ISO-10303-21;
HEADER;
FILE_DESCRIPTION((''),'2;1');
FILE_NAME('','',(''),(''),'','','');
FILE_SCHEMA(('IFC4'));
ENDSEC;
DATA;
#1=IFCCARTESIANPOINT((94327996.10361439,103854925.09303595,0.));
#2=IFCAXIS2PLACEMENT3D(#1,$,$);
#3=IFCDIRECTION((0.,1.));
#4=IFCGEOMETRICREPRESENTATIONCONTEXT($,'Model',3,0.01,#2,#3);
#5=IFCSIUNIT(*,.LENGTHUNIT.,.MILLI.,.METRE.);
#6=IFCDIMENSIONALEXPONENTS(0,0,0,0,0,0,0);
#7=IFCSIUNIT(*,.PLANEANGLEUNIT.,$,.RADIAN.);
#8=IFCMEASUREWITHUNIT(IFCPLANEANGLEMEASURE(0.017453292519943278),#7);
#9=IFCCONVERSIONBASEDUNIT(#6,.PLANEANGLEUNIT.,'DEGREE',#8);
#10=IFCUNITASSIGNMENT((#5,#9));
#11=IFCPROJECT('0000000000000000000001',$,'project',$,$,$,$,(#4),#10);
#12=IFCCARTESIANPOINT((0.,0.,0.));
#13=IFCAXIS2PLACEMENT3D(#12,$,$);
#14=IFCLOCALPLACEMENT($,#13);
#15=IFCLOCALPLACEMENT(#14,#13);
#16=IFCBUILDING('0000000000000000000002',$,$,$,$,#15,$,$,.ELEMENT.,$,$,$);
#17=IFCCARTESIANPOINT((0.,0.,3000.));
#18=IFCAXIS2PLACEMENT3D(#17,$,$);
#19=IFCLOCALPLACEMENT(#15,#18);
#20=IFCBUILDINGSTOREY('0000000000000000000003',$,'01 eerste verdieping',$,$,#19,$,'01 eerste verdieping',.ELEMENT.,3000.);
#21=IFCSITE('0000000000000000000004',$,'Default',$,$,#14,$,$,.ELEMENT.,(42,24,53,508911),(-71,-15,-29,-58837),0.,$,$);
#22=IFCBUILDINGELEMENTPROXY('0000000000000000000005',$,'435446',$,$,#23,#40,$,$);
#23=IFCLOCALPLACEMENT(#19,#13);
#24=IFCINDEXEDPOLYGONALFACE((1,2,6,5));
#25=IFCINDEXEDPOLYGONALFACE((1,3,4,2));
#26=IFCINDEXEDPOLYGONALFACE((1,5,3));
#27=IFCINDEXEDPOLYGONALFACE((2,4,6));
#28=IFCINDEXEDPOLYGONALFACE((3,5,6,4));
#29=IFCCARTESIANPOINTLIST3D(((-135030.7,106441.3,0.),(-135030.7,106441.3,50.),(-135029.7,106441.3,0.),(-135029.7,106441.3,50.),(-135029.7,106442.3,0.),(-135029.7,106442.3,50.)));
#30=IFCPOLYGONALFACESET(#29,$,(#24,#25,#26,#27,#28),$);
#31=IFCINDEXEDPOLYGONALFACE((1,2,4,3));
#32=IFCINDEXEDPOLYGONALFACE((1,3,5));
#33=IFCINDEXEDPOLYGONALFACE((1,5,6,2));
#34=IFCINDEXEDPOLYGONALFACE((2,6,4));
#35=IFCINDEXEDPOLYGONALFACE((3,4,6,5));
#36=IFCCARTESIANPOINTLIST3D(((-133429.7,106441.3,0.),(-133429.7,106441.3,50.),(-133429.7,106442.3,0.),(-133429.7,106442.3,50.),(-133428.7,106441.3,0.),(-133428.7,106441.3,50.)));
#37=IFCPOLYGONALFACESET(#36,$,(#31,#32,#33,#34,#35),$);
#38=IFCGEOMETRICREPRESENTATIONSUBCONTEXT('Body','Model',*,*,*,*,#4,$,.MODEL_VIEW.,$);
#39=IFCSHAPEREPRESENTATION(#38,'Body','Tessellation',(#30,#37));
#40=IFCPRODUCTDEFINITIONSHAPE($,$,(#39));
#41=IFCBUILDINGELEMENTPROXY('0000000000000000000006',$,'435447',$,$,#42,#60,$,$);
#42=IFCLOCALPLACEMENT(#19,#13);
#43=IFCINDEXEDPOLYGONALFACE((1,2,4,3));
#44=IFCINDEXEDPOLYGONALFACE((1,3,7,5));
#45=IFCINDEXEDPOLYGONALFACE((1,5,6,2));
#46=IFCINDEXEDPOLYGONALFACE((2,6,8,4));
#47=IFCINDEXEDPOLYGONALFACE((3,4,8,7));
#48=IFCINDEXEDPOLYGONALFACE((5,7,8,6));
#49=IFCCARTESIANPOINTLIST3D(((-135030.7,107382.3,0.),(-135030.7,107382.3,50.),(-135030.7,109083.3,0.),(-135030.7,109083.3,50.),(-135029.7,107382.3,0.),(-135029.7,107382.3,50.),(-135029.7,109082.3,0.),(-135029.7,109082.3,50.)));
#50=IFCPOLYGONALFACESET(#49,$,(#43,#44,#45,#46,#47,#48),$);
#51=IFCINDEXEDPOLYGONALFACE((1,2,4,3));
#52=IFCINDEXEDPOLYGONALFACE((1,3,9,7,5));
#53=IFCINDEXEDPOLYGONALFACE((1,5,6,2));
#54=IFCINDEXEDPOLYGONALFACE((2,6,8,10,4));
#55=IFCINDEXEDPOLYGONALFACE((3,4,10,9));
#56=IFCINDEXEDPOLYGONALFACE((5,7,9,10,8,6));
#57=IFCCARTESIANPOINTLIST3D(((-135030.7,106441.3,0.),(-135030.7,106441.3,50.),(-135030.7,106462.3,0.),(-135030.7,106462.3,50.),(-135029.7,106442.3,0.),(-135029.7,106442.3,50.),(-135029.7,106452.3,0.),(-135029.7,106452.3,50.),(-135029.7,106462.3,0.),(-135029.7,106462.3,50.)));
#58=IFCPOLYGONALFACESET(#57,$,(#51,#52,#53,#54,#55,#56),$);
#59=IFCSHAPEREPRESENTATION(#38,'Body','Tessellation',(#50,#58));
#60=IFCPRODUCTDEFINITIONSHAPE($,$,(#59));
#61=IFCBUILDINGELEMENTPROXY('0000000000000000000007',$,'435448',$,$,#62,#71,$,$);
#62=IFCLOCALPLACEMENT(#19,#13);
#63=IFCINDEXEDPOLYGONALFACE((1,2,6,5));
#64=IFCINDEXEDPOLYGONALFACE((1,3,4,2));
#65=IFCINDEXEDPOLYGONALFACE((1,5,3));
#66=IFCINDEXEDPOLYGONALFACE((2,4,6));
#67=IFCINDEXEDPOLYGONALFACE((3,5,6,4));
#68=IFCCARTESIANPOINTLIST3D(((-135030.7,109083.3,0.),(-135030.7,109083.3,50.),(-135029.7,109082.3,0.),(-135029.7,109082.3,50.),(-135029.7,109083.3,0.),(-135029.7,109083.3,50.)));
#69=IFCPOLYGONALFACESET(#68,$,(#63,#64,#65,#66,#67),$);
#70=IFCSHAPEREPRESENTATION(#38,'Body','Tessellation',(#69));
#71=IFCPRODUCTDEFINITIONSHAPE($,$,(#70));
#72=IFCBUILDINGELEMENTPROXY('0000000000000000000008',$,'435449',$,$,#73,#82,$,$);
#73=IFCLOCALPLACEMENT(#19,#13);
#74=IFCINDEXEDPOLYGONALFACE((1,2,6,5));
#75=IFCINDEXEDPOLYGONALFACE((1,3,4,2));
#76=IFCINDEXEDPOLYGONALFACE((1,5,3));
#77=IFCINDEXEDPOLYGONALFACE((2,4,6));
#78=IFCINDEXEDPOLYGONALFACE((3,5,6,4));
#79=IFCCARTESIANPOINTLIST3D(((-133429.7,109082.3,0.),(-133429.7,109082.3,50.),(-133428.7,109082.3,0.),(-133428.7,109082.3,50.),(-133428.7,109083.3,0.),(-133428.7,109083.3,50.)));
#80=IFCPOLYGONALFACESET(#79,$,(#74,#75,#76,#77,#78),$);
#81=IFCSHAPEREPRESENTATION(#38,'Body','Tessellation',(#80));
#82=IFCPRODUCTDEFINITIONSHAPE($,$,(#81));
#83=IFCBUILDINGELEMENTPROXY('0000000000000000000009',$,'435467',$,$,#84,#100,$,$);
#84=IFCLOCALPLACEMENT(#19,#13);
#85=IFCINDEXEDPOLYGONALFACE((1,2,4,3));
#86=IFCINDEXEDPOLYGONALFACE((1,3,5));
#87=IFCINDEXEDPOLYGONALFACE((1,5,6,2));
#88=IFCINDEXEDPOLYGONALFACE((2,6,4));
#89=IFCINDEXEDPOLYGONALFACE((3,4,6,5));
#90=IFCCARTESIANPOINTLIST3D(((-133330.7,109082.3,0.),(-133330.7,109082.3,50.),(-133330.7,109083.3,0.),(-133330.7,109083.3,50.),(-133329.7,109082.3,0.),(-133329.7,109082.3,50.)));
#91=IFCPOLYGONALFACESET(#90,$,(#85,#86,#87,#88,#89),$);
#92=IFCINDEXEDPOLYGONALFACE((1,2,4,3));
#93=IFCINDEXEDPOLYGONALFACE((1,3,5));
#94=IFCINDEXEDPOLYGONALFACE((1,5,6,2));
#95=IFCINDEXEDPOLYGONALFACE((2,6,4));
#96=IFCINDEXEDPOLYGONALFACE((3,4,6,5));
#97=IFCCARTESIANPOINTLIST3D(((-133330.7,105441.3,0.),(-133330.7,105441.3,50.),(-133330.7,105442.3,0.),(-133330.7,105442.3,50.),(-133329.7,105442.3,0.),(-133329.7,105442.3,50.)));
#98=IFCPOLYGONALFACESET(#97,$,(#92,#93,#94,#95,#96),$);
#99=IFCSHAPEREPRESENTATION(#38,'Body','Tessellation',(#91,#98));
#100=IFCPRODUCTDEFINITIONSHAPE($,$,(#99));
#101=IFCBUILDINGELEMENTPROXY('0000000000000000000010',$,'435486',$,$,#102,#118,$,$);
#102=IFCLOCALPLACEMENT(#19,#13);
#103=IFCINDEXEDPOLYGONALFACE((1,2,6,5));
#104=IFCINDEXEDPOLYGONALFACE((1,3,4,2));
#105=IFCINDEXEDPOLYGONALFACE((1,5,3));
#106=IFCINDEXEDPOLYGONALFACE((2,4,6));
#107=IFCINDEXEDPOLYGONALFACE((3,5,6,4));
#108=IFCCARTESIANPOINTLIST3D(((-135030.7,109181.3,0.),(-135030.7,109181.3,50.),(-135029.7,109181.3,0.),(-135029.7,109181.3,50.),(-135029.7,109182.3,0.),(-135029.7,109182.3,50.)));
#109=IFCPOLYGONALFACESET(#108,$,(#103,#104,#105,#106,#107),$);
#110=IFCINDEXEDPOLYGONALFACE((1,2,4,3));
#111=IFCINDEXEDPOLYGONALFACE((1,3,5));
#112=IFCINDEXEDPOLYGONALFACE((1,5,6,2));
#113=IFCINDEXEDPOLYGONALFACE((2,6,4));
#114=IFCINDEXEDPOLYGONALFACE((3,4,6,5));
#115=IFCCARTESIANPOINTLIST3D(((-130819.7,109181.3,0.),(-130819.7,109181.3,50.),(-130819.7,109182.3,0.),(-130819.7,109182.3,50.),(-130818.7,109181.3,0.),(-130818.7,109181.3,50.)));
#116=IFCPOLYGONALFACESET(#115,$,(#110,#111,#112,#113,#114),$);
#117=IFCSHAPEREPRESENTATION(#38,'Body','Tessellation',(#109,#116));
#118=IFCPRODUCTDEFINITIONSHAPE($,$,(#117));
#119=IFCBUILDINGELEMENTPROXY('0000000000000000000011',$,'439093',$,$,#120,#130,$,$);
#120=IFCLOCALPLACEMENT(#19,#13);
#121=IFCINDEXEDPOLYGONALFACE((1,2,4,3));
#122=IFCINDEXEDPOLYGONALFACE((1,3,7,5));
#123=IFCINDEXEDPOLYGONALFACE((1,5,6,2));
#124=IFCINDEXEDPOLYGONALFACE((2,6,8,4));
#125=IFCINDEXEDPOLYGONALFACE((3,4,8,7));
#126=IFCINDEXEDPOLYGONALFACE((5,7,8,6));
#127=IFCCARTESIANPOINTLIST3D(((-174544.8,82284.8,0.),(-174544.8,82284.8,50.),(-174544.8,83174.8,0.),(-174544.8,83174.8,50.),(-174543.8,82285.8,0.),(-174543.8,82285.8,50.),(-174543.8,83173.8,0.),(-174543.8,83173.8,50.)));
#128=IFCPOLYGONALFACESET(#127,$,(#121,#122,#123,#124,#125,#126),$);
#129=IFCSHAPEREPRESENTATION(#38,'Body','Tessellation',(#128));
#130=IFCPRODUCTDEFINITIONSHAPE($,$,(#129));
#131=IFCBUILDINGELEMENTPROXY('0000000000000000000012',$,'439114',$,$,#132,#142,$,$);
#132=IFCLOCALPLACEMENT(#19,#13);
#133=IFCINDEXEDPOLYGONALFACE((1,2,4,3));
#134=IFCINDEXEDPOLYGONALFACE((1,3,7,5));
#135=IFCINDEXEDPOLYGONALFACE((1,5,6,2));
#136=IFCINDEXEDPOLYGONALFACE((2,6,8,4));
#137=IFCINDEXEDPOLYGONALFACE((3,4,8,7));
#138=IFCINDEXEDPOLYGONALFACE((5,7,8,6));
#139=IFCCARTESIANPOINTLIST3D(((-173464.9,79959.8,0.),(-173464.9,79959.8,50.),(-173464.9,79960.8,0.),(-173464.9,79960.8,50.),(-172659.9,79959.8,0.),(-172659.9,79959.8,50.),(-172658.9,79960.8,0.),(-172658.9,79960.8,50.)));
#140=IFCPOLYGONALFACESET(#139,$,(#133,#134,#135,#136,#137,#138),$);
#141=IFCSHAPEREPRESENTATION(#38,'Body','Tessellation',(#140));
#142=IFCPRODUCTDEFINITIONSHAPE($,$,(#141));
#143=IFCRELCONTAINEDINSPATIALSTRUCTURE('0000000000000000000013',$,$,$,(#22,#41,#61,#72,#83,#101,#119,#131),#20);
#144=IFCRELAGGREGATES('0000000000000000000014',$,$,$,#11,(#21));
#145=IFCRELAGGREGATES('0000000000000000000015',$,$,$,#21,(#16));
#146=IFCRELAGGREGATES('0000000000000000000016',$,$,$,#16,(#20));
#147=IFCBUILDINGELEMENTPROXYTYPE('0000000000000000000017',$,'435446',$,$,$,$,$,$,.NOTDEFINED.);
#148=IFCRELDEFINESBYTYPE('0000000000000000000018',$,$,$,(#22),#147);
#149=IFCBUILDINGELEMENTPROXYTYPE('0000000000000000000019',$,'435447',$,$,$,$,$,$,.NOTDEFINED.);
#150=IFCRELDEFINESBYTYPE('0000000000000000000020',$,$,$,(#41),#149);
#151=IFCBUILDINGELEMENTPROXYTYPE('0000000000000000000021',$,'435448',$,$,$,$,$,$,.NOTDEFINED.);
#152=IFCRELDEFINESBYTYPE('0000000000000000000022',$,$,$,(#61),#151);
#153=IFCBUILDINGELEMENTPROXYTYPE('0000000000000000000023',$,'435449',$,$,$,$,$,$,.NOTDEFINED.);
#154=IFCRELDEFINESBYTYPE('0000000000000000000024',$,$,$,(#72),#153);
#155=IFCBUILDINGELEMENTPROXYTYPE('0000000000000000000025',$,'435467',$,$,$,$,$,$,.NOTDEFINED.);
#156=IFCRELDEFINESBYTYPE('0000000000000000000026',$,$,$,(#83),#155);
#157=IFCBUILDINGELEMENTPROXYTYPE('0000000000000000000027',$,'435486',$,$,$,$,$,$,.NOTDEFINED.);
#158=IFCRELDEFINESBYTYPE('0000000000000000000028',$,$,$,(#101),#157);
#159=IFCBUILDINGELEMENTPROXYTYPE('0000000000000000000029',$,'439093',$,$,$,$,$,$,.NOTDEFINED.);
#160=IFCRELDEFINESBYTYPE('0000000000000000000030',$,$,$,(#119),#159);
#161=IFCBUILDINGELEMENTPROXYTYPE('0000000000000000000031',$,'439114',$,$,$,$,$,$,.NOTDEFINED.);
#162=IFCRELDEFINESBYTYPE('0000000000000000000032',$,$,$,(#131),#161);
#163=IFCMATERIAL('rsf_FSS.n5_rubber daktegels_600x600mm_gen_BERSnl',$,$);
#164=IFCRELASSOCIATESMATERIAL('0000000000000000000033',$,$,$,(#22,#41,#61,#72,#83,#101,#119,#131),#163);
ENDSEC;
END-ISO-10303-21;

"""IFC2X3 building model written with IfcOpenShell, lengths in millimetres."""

from ifc_helpers import new_model, entity, si_unit, converted_unit, direction, frame, origin, place, context, subcontext, project, spatial, polyline, outline, extrude, material, type_object, element, save


model = new_model("IFC2X3")

# Units and contexts
model_context = context("Model", 3, precision=0.01, world=frame((94327996.10361439, 103854925.09303595, 0.0)), true_north=direction((0.0, 1.0)))
body_context = subcontext(model_context, "Body", "Model", "MODEL_VIEW")
ifc_project = project(units=[si_unit("LENGTHUNIT", "METRE", prefix="MILLI"), converted_unit("PLANEANGLEUNIT", "DEGREE", entity("IfcPlaneAngleMeasure", 0.017453292519943278), si_unit("PLANEANGLEUNIT", "RADIAN"), dimensions=[0, 0, 0, 0, 0, 0, 0])], contexts=[model_context])

# Site, building, storey
site_placement = place(None, origin())
site = spatial("IfcSite", under=ifc_project, at=site_placement, Name="Default", CompositionType="ELEMENT", RefLatitude=(42, 24, 53, 508911), RefLongitude=(-71, -15, -29, -58837), RefElevation=0.0)
building_placement = place(site_placement, origin())
building = spatial("IfcBuilding", under=site, at=building_placement, CompositionType="ELEMENT")
storey_placement = place(building_placement, frame((0.0, 0.0, 3000.0)))
storey = spatial("IfcBuildingStorey", under=building, at=storey_placement, Name="01 eerste verdieping", LongName="01 eerste verdieping", CompositionType="ELEMENT", Elevation=3000.0)

# Building element proxies
ifc_material = material(Name="rsf_FSS.n5_rubber daktegels_600x600mm_gen_BERSnl")
building_element_proxy_type_1 = type_object("IfcBuildingElementProxyType", Name="435446", PredefinedType="NOTDEFINED")
proxy_1_placement = place(storey_placement, origin())
element("IfcBuildingElementProxy", 1, at=proxy_1_placement, inside=storey, type_object=building_element_proxy_type_1, material=ifc_material, Name="435446", context=body_context, shape_type="SweptSolid", body=[
    extrude(outline(polyline([(-0.7, -0.3), (0.3, -0.3), (0.3, 0.7), (-0.7, -0.3)])), frame((-135030.0, 106441.7, 0.0)), (0.0, 0.0, 1.0), 50.0),
    extrude(outline(polyline([(-0.7, -0.3), (0.3, -0.3), (0.3, 0.7), (-0.7, -0.3)])), frame((-133429.4, 106441.7, 0.0), z_axis=(0.0, 0.0, 1.0), x_axis=(0.0, -1.0, 0.0)), (0.0, 0.0, 1.0), 50.0),
])
building_element_proxy_type_2 = type_object("IfcBuildingElementProxyType", Name="435447", PredefinedType="NOTDEFINED")
proxy_2_placement = place(storey_placement, origin())
element("IfcBuildingElementProxy", 2, at=proxy_2_placement, inside=storey, type_object=building_element_proxy_type_2, material=ifc_material, Name="435447", context=body_context, shape_type="SweptSolid", body=[
    extrude(outline(polyline([(-850.8, -0.5), (850.3, -0.5), (850.3, 0.5), (-849.8, 0.5), (-850.8, -0.5)])), frame((-135030.2, 108232.6, 0.0), z_axis=(0.0, 0.0, 1.0), x_axis=(0.0, -1.0, 0.0)), (0.0, 0.0, 1.0), 50.0),
    extrude(outline(polyline([(-10.2, -0.6), (10.8, -0.6), (9.8, 0.4), (-0.2, 0.4), (-10.2, 0.4), (-10.2, -0.6)])), frame((-135030.1, 106452.1, 0.0), z_axis=(0.0, 0.0, 1.0), x_axis=(0.0, -1.0, 0.0)), (0.0, 0.0, 1.0), 50.0),
])
building_element_proxy_type_3 = type_object("IfcBuildingElementProxyType", Name="435448", PredefinedType="NOTDEFINED")
proxy_3_placement = place(storey_placement, origin())
element("IfcBuildingElementProxy", 3, at=proxy_3_placement, inside=storey, type_object=building_element_proxy_type_3, material=ifc_material, Name="435448", context=body_context, shape_type="SweptSolid", body=[
    extrude(outline(polyline([(-0.7, -0.3), (0.3, -0.3), (0.3, 0.7), (-0.7, -0.3)])), frame((-135030.0, 109083.0, 0.0), z_axis=(0.0, 0.0, 1.0), x_axis=(0.0, 1.0, 0.0)), (0.0, 0.0, 1.0), 50.0),
])
building_element_proxy_type_4 = type_object("IfcBuildingElementProxyType", Name="435449", PredefinedType="NOTDEFINED")
proxy_4_placement = place(storey_placement, origin())
element("IfcBuildingElementProxy", 4, at=proxy_4_placement, inside=storey, type_object=building_element_proxy_type_4, material=ifc_material, Name="435449", context=body_context, shape_type="SweptSolid", body=[
    extrude(outline(polyline([(-0.7, -0.3), (0.3, -0.3), (0.3, 0.7), (-0.7, -0.3)])), frame((-133429.0, 109082.7, 0.0)), (0.0, 0.0, 1.0), 50.0),
])
building_element_proxy_type_5 = type_object("IfcBuildingElementProxyType", Name="435467", PredefinedType="NOTDEFINED")
proxy_5_placement = place(storey_placement, origin())
element("IfcBuildingElementProxy", 5, at=proxy_5_placement, inside=storey, type_object=building_element_proxy_type_5, material=ifc_material, Name="435467", context=body_context, shape_type="SweptSolid", body=[
    extrude(outline(polyline([(-0.7, -0.3), (0.3, -0.3), (0.3, 0.7), (-0.7, -0.3)])), frame((-133330.4, 109082.7, 0.0), z_axis=(0.0, 0.0, 1.0), x_axis=(0.0, -1.0, 0.0)), (0.0, 0.0, 1.0), 50.0),
    extrude(outline(polyline([(-0.7, -0.3), (0.3, -0.3), (0.3, 0.7), (-0.7, -0.3)])), frame((-133330.4, 105442.0, 0.0), z_axis=(0.0, 0.0, 1.0), x_axis=(-1.0, 0.0, 0.0)), (0.0, 0.0, 1.0), 50.0),
])
building_element_proxy_type_6 = type_object("IfcBuildingElementProxyType", Name="435486", PredefinedType="NOTDEFINED")
proxy_6_placement = place(storey_placement, origin())
element("IfcBuildingElementProxy", 6, at=proxy_6_placement, inside=storey, type_object=building_element_proxy_type_6, material=ifc_material, Name="435486", context=body_context, shape_type="SweptSolid", body=[
    extrude(outline(polyline([(-0.7, -0.3), (0.3, -0.3), (0.3, 0.7), (-0.7, -0.3)])), frame((-135030.0, 109181.7, 0.0)), (0.0, 0.0, 1.0), 50.0),
    extrude(outline(polyline([(-0.7, -0.3), (0.3, -0.3), (0.3, 0.7), (-0.7, -0.3)])), frame((-130819.4, 109181.7, 0.0), z_axis=(0.0, 0.0, 1.0), x_axis=(0.0, -1.0, 0.0)), (0.0, 0.0, 1.0), 50.0),
])
building_element_proxy_type_7 = type_object("IfcBuildingElementProxyType", Name="439093", PredefinedType="NOTDEFINED")
proxy_7_placement = place(storey_placement, origin())
element("IfcBuildingElementProxy", 7, at=proxy_7_placement, inside=storey, type_object=building_element_proxy_type_7, material=ifc_material, Name="439093", context=body_context, shape_type="SweptSolid", body=[
    extrude(outline(polyline([(-445.0, -0.5), (445.0, -0.5), (444.0, 0.5), (-444.0, 0.5), (-445.0, -0.5)])), frame((-174544.3, 82729.8, 0.0), z_axis=(0.0, 0.0, 1.0), x_axis=(0.0, -1.0, 0.0)), (0.0, 0.0, 1.0), 50.0),
])
building_element_proxy_type_8 = type_object("IfcBuildingElementProxyType", Name="439114", PredefinedType="NOTDEFINED")
proxy_8_placement = place(storey_placement, origin())
element("IfcBuildingElementProxy", 8, at=proxy_8_placement, inside=storey, type_object=building_element_proxy_type_8, material=ifc_material, Name="439114", context=body_context, shape_type="SweptSolid", body=[
    extrude(outline(polyline([(-403.3, -0.5), (402.8, -0.5), (402.8, 0.5), (-402.3, 0.5), (-403.3, -0.5)])), frame((-173062.1, 79960.3, 0.0), z_axis=(0.0, 0.0, 1.0), x_axis=(-1.0, 0.0, 0.0)), (0.0, 0.0, 1.0), 50.0),
])

save(model, "model.ifc")
